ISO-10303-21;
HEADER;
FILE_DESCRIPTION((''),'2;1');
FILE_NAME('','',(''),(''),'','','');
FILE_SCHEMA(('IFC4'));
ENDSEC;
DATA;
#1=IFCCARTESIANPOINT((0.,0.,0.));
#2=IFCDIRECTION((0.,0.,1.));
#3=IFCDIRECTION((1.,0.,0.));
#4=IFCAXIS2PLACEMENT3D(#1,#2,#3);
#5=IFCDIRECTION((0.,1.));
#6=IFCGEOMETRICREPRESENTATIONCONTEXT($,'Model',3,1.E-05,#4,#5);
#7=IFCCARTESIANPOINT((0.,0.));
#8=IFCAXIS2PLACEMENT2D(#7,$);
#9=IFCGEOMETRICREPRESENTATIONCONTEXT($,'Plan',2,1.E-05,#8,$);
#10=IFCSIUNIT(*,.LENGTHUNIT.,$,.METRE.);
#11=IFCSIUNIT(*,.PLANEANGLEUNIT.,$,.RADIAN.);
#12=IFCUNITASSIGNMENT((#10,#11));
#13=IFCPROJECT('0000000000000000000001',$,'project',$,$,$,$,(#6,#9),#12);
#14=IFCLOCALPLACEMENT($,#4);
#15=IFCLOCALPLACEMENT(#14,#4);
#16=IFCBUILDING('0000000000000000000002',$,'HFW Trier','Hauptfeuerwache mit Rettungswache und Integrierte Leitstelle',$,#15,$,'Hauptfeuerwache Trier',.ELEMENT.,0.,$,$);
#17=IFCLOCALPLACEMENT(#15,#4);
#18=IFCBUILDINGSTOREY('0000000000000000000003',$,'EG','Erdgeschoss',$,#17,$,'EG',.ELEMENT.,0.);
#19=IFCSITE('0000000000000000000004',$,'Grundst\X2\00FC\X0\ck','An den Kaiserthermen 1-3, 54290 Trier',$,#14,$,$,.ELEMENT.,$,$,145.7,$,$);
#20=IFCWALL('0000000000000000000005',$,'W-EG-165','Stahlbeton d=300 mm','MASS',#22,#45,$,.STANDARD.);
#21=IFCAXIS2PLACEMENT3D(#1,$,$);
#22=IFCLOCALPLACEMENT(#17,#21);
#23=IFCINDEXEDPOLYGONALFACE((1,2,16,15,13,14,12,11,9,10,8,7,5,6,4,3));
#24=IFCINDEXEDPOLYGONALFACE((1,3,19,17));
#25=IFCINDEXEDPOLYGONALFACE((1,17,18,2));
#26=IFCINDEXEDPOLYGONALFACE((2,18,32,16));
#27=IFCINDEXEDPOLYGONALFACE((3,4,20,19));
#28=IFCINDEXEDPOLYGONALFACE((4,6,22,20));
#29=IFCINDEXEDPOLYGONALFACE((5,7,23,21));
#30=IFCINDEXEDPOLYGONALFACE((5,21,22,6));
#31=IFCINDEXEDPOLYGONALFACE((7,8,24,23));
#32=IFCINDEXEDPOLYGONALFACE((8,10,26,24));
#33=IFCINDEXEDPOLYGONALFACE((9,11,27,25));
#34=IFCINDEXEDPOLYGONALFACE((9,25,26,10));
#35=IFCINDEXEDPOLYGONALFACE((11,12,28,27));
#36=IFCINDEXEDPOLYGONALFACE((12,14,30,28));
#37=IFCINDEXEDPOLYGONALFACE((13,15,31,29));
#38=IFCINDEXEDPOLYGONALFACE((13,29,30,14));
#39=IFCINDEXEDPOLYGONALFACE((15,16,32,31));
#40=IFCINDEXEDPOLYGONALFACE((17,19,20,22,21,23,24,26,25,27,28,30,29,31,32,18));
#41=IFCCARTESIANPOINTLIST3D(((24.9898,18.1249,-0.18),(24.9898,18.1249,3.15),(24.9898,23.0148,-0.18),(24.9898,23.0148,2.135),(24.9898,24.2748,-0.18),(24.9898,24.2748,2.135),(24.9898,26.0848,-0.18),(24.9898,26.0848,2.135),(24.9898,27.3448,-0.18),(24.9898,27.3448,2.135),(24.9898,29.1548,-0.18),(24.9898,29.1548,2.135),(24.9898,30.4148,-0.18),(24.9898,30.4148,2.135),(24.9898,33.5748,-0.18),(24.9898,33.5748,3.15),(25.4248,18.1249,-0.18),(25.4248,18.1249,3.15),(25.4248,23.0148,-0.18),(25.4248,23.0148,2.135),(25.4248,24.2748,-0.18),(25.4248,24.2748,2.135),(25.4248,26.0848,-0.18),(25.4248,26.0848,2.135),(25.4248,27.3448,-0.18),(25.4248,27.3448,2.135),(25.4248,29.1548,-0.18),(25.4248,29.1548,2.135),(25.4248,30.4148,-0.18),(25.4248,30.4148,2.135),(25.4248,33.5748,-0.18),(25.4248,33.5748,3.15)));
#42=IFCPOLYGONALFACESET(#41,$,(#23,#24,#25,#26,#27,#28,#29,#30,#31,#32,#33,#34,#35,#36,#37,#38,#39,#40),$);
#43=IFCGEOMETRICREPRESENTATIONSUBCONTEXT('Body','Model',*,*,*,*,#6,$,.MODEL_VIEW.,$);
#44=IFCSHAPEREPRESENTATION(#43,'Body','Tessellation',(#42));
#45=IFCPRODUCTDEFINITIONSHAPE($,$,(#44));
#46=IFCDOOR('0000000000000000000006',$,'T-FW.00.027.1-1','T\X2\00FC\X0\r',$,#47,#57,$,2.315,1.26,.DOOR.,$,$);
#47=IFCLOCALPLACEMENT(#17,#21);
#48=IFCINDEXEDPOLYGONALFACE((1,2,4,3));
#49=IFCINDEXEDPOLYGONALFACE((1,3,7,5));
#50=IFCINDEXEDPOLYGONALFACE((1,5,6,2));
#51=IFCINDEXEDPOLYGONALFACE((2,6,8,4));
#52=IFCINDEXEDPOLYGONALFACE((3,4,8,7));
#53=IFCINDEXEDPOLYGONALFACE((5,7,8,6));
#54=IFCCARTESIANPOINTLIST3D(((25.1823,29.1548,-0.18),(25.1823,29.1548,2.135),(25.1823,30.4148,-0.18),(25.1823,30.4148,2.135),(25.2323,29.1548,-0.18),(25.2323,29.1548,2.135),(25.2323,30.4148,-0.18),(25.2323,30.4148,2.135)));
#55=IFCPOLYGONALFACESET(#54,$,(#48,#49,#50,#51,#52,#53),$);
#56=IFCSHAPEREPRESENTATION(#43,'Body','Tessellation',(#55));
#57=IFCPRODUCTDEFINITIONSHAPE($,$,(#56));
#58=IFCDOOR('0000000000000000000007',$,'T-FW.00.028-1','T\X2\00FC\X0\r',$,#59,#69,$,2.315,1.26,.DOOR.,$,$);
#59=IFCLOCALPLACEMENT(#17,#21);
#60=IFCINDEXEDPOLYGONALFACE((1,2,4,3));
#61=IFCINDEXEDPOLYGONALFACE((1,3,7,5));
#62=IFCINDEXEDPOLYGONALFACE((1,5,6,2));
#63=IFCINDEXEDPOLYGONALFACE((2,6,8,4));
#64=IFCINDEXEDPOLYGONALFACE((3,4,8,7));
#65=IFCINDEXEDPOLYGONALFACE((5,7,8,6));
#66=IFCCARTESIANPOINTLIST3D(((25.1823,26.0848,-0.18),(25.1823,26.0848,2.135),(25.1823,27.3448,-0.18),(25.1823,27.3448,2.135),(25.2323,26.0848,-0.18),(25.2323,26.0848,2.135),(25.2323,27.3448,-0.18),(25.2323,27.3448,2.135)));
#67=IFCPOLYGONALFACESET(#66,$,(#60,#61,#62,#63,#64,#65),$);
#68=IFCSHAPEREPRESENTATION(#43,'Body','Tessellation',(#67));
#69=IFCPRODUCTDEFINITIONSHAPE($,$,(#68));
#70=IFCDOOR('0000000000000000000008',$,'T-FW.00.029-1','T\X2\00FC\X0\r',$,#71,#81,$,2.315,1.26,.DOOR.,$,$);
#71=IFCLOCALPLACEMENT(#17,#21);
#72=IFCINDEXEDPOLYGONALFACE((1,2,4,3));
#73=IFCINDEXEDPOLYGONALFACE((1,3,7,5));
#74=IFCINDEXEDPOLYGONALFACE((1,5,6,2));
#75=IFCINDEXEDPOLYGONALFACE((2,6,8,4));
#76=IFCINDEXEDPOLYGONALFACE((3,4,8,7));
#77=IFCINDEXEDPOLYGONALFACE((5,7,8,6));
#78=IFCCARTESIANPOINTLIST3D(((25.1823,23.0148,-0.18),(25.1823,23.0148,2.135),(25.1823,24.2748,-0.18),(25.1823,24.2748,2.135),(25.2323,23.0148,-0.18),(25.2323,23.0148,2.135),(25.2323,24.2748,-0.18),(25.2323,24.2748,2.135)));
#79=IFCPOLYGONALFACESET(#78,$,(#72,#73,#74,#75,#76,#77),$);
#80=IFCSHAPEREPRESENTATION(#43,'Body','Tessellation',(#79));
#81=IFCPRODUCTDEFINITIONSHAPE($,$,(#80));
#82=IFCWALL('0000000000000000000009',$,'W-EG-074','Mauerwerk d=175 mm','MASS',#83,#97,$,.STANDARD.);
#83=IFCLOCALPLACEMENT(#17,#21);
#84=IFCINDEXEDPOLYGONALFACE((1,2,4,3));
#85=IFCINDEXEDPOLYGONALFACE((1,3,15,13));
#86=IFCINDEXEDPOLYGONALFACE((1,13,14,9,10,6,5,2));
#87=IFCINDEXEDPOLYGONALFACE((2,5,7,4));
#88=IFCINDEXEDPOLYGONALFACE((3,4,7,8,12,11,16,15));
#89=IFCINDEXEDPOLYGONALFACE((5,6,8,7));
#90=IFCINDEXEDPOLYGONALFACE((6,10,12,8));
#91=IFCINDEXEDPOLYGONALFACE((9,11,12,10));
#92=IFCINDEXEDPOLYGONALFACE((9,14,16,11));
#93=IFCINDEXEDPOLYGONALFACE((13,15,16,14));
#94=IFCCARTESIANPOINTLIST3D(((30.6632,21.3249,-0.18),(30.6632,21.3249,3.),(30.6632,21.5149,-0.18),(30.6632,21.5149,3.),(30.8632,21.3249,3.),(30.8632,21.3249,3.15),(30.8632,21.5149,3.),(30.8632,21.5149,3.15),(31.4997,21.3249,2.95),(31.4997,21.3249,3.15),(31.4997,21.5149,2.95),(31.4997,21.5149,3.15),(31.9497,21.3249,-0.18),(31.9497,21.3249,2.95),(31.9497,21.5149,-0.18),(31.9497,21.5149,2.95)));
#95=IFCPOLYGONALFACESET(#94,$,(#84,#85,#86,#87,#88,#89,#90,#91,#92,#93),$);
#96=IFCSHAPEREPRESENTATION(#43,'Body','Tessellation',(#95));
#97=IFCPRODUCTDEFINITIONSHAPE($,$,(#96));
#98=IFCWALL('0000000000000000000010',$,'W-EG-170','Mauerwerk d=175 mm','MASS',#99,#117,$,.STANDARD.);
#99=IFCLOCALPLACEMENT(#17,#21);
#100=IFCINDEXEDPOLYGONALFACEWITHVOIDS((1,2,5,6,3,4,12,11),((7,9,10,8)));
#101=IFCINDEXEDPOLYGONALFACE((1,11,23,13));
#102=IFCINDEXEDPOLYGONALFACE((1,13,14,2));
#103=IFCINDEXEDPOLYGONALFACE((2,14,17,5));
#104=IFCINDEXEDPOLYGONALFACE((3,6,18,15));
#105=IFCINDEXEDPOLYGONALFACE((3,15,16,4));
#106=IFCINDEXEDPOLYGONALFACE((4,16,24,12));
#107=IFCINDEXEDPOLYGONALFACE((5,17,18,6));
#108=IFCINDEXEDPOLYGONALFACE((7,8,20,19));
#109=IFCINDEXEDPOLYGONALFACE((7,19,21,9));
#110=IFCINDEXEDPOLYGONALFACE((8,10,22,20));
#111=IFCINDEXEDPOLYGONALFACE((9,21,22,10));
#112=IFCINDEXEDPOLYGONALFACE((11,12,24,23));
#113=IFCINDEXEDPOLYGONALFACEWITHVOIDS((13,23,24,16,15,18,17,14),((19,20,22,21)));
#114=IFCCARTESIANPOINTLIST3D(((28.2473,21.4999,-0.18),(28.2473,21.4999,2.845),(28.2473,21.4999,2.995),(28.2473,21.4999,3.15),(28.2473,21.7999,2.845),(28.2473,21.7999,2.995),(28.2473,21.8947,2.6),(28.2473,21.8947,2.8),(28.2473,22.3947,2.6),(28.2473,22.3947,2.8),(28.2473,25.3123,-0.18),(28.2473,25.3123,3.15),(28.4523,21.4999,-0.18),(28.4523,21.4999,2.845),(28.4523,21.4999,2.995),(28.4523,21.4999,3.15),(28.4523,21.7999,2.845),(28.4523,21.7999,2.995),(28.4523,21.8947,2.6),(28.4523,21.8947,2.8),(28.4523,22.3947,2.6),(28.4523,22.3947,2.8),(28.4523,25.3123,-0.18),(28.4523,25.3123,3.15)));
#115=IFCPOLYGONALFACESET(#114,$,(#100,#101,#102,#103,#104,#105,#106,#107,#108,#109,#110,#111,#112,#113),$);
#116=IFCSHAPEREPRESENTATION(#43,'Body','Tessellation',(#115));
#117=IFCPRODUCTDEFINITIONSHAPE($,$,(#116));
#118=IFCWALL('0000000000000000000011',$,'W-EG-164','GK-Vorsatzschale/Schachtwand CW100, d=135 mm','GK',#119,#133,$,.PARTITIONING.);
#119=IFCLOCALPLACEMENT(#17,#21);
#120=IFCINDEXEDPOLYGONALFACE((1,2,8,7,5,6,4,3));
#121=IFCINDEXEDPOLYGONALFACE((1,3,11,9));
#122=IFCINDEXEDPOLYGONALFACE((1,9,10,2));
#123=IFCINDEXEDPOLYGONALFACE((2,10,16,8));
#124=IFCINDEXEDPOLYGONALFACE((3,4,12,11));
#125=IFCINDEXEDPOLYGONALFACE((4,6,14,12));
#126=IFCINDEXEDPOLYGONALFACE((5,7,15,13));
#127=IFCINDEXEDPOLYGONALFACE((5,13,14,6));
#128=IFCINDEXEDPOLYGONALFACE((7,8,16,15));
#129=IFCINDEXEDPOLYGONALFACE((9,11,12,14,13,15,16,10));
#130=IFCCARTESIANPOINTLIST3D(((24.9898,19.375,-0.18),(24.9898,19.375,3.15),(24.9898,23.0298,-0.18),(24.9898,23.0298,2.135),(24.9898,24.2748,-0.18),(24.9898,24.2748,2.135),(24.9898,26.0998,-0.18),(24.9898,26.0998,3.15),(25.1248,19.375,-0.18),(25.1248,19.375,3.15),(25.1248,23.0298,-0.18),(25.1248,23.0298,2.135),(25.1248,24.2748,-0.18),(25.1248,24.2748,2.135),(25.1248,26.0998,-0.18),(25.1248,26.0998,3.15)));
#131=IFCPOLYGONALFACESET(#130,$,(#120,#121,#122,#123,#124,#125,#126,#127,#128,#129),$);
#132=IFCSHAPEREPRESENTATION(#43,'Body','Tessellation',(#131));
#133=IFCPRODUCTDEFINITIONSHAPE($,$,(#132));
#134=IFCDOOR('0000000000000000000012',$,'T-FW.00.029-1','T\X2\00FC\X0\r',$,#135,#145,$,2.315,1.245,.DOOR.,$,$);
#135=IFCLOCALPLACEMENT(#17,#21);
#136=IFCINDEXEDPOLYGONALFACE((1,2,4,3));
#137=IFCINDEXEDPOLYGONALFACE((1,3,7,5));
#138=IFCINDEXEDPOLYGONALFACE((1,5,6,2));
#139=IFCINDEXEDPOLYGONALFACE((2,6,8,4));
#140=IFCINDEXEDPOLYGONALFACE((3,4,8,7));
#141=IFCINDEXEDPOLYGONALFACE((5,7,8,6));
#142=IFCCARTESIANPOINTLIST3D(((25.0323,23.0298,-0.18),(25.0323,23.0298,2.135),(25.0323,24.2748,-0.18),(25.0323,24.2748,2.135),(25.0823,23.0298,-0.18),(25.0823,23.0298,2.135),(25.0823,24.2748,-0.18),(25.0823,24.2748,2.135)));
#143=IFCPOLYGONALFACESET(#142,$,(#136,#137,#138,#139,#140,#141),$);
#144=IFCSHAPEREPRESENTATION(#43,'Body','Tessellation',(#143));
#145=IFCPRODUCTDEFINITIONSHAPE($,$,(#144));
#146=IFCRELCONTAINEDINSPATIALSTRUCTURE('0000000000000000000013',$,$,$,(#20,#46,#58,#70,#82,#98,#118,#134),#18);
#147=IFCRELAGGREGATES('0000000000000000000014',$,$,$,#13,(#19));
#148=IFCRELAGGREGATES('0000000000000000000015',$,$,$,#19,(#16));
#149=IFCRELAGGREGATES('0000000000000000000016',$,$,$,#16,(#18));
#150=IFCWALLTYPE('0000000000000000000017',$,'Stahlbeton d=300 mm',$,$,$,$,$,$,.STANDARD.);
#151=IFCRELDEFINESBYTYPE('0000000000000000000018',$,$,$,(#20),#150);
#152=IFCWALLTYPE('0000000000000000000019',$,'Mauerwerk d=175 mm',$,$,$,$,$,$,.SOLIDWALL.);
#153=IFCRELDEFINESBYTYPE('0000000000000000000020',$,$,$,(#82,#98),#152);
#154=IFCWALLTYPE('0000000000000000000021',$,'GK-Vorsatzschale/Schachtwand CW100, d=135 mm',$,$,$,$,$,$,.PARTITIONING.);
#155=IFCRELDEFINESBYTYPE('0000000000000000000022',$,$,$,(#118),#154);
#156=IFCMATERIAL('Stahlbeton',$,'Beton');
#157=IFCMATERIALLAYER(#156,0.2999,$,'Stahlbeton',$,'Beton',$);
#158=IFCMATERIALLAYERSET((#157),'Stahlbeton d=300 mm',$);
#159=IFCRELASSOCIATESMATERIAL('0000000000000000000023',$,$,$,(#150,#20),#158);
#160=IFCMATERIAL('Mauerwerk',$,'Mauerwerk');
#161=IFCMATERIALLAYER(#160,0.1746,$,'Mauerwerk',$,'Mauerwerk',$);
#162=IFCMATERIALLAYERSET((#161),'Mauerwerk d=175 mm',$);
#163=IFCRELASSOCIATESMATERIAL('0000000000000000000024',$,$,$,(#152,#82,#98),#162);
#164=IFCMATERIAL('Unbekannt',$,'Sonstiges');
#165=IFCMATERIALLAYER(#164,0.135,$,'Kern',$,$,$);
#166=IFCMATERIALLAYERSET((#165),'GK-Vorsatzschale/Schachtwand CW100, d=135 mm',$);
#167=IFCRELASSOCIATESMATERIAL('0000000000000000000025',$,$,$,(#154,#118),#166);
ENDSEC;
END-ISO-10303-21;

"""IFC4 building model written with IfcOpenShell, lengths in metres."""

from ifc_helpers import new_model, si_unit, direction, frame, frame_2d, origin_with_axes, origin_2d, place, context, subcontext, project, spatial, rectangle, extrude, material, layer, layer_set, layer_usage, type_object, element, fill, save


model = new_model("IFC4")

# Units and contexts
model_context = context("Model", 3, precision=1e-05, world=origin_with_axes(), true_north=direction((0.0, 1.0)))
plan_context = context("Plan", 2, precision=1e-05, world=origin_2d())
body_context = subcontext(model_context, "Body", "Model", "MODEL_VIEW")
ifc_project = project(units=[si_unit("LENGTHUNIT", "METRE"), si_unit("PLANEANGLEUNIT", "RADIAN")], contexts=[model_context, plan_context])

# Site, building, storey
site_placement = place(None, origin_with_axes())
site = spatial("IfcSite", under=ifc_project, at=site_placement, Name="Grundstück", Description="An den Kaiserthermen 1-3, 54290 Trier", CompositionType="ELEMENT", RefElevation=145.7)
building_placement = place(site_placement, origin_with_axes())
building = spatial("IfcBuilding", under=site, at=building_placement, Name="HFW Trier", Description="Hauptfeuerwache mit Rettungswache und Integrierte Leitstelle", LongName="Hauptfeuerwache Trier", CompositionType="ELEMENT", ElevationOfRefHeight=0.0)
storey_placement = place(building_placement, origin_with_axes())
storey = spatial("IfcBuildingStorey", under=building, at=storey_placement, Name="EG", Description="Erdgeschoss", LongName="EG", CompositionType="ELEMENT", Elevation=0.0)

# Wall, openings, doors
ifc_material_1 = material(Name="Stahlbeton", Category="Beton")
ifc_layer_1 = layer(ifc_material_1, 0.2999, Name="Stahlbeton", Category="Beton")
ifc_layer_set_1 = layer_set([ifc_layer_1], Name="Stahlbeton d=300 mm")
ifc_layer_usage_1 = layer_usage(ifc_layer_set_1, "AXIS2", "POSITIVE", -0.2175)
wall_type_1 = type_object("IfcWallType", Name="Stahlbeton d=300 mm", PredefinedType="STANDARD", material=ifc_layer_set_1)
wall_1_placement = place(storey_placement, frame((25.2073, 33.5748, -0.18), z_axis=(0.0, 0.0, 1.0), x_axis=(0.0, -1.0, 0.0)))
wall_1 = element("IfcWall", 1, at=wall_1_placement, inside=storey, type_object=wall_type_1, material=ifc_layer_usage_1, Name="W-EG-165", Description="Stahlbeton d=300 mm", ObjectType="MASS", PredefinedType="STANDARD", context=body_context, shape_type="SweptSolid", body=[
    extrude(rectangle(XDim=15.4499, YDim=0.435, at=frame_2d((7.725, 0.0))), origin_with_axes(), (0.0, 0.0, 1.0), 3.33),
])
opening_1_placement = place(wall_1_placement, frame((3.16, 0.0, 0.0), z_axis=(0.0, 0.0, 1.0), x_axis=(1.0, 0.0, 0.0)))
opening_1 = element("IfcOpeningElement", 2, at=opening_1_placement, cuts=wall_1, PredefinedType="OPENING", context=body_context, shape_type="SweptSolid", body=[
    extrude(rectangle(XDim=1.26, YDim=0.535, at=frame_2d((0.63, 0.0))), origin_with_axes(), (0.0, 0.0, 1.0), 2.315),
])
opening_2_placement = place(wall_1_placement, frame((6.23, 0.0, 0.0), z_axis=(0.0, 0.0, 1.0), x_axis=(1.0, 0.0, 0.0)))
opening_2 = element("IfcOpeningElement", 3, at=opening_2_placement, cuts=wall_1, PredefinedType="OPENING", context=body_context, shape_type="SweptSolid", body=[
    extrude(rectangle(XDim=1.26, YDim=0.535, at=frame_2d((0.63, 0.0))), origin_with_axes(), (0.0, 0.0, 1.0), 2.315),
])
opening_3_placement = place(wall_1_placement, frame((9.3, 0.0, 0.0), z_axis=(0.0, 0.0, 1.0), x_axis=(1.0, 0.0, 0.0)))
opening_3 = element("IfcOpeningElement", 4, at=opening_3_placement, cuts=wall_1, PredefinedType="OPENING", context=body_context, shape_type="SweptSolid", body=[
    extrude(rectangle(XDim=1.26, YDim=0.535, at=frame_2d((0.63, 0.0))), origin_with_axes(), (0.0, 0.0, 1.0), 2.315),
])
door_1_placement = place(wall_1_placement, frame((3.16, 0.0, 0.0), z_axis=(0.0, 0.0, 1.0), x_axis=(1.0, 0.0, 0.0)))
door_1 = element("IfcDoor", 5, at=door_1_placement, inside=storey, Name="T-FW.00.027.1-1", Description="Tür", OverallHeight=2.315, OverallWidth=1.26, PredefinedType="DOOR", context=body_context, shape_type="SweptSolid", body=[
    extrude(rectangle(XDim=1.26, YDim=0.05, at=frame_2d((0.63, 0.0))), origin_with_axes(), (0.0, 0.0, 1.0), 2.315),
])
fill(opening_1, door_1)
door_2_placement = place(wall_1_placement, frame((6.23, 0.0, 0.0), z_axis=(0.0, 0.0, 1.0), x_axis=(1.0, 0.0, 0.0)))
door_2 = element("IfcDoor", 6, at=door_2_placement, inside=storey, Name="T-FW.00.028-1", Description="Tür", OverallHeight=2.315, OverallWidth=1.26, PredefinedType="DOOR", context=body_context, shape_type="SweptSolid", body=[
    extrude(rectangle(XDim=1.26, YDim=0.05, at=frame_2d((0.63, 0.0))), origin_with_axes(), (0.0, 0.0, 1.0), 2.315),
])
fill(opening_2, door_2)
door_3_placement = place(wall_1_placement, frame((9.3, 0.0, 0.0), z_axis=(0.0, 0.0, 1.0), x_axis=(1.0, 0.0, 0.0)))
door_3 = element("IfcDoor", 7, at=door_3_placement, inside=storey, Name="T-FW.00.029-1", Description="Tür", OverallHeight=2.315, OverallWidth=1.26, PredefinedType="DOOR", context=body_context, shape_type="SweptSolid", body=[
    extrude(rectangle(XDim=1.26, YDim=0.05, at=frame_2d((0.63, 0.0))), origin_with_axes(), (0.0, 0.0, 1.0), 2.315),
])
fill(opening_3, door_3)

# Walls, openings
ifc_material_2 = material(Name="Mauerwerk", Category="Mauerwerk")
ifc_layer_2 = layer(ifc_material_2, 0.1746, Name="Mauerwerk", Category="Mauerwerk")
ifc_layer_set_2 = layer_set([ifc_layer_2], Name="Mauerwerk d=175 mm")
wall_type_2 = type_object("IfcWallType", Name="Mauerwerk d=175 mm", PredefinedType="SOLIDWALL", material=ifc_layer_set_2)
ifc_layer_usage_2 = layer_usage(ifc_layer_set_2, "AXIS2", "POSITIVE", -0.095)
wall_2_placement = place(storey_placement, frame((30.6632, 21.4199, -0.18), z_axis=(0.0, 0.0, 1.0), x_axis=(1.0, 0.0, 0.0)))
wall_2 = element("IfcWall", 8, at=wall_2_placement, inside=storey, type_object=wall_type_2, material=ifc_layer_usage_2, Name="W-EG-074", Description="Mauerwerk d=175 mm", ObjectType="MASS", PredefinedType="STANDARD", context=body_context, shape_type="SweptSolid", body=[
    extrude(rectangle(XDim=1.2865, YDim=0.19, at=frame_2d((0.6433, 0.0))), origin_with_axes(), (0.0, 0.0, 1.0), 3.33),
])
opening_4_placement = place(wall_2_placement, origin_with_axes())
element("IfcOpeningElement", 9, at=opening_4_placement, cuts=wall_2, ObjectType="Wanddurchbruch", PredefinedType="OPENING", context=body_context, shape_type="SweptSolid", body=[
    extrude(rectangle(XDim=0.2, YDim=0.29, at=frame_2d((0.1, 0.0))), frame((0.0, 0.0, 3.18), z_axis=(0.0, 0.0, 1.0), x_axis=(1.0, 0.0, 0.0)), (0.0, 0.0, 1.0), 0.15),
])
opening_5_placement = place(wall_2_placement, origin_with_axes())
element("IfcOpeningElement", 10, at=opening_5_placement, cuts=wall_2, ObjectType="Wanddurchbruch", PredefinedType="OPENING", context=body_context, shape_type="SweptSolid", body=[
    extrude(rectangle(XDim=0.45, YDim=0.29, at=frame_2d((1.0615, 0.0))), frame((0.0, 0.0, 3.13), z_axis=(0.0, 0.0, 1.0), x_axis=(1.0, 0.0, 0.0)), (0.0, 0.0, 1.0), 0.2),
])
ifc_layer_usage_3 = layer_usage(ifc_layer_set_2, "AXIS2", "POSITIVE", -0.1025)
wall_3_placement = place(storey_placement, frame((28.3498, 25.3123, -0.18), z_axis=(0.0, 0.0, 1.0), x_axis=(0.0, -1.0, 0.0)))
wall_3 = element("IfcWall", 11, at=wall_3_placement, inside=storey, type_object=wall_type_2, material=ifc_layer_usage_3, Name="W-EG-170", Description="Mauerwerk d=175 mm", ObjectType="MASS", PredefinedType="STANDARD", context=body_context, shape_type="SweptSolid", body=[
    extrude(rectangle(XDim=3.8124, YDim=0.205, at=frame_2d((1.9062, 0.0))), origin_with_axes(), (0.0, 0.0, 1.0), 3.33),
])
opening_6_placement = place(wall_3_placement, origin_with_axes())
element("IfcOpeningElement", 12, at=opening_6_placement, cuts=wall_3, ObjectType="Wanddurchbruch", PredefinedType="OPENING", context=body_context, shape_type="SweptSolid", body=[
    extrude(rectangle(XDim=0.3, YDim=0.305, at=frame_2d((3.6624, 0.0))), frame((0.0, 0.0, 3.025), z_axis=(0.0, 0.0, 1.0), x_axis=(1.0, 0.0, 0.0)), (0.0, 0.0, 1.0), 0.15),
])
opening_7_placement = place(wall_3_placement, origin_with_axes())
element("IfcOpeningElement", 13, at=opening_7_placement, cuts=wall_3, ObjectType="Wanddurchbruch", PredefinedType="OPENING", context=body_context, shape_type="SweptSolid", body=[
    extrude(rectangle(XDim=0.5, YDim=0.305, at=frame_2d((3.1676, 0.0))), frame((0.0, 0.0, 2.78), z_axis=(0.0, 0.0, 1.0), x_axis=(1.0, 0.0, 0.0)), (0.0, 0.0, 1.0), 0.2),
])

# Wall, opening, door
ifc_material_3 = material(Name="Unbekannt", Category="Sonstiges")
ifc_layer_3 = layer(ifc_material_3, 0.135, Name="Kern")
ifc_layer_set_3 = layer_set([ifc_layer_3], Name="GK-Vorsatzschale/Schachtwand CW100, d=135 mm")
ifc_layer_usage_4 = layer_usage(ifc_layer_set_3, "AXIS2", "POSITIVE", -0.0675)
wall_type_3 = type_object("IfcWallType", Name="GK-Vorsatzschale/Schachtwand CW100, d=135 mm", PredefinedType="PARTITIONING", material=ifc_layer_set_3)
wall_4_placement = place(storey_placement, frame((25.0573, 26.0998, -0.18), z_axis=(0.0, 0.0, 1.0), x_axis=(0.0, -1.0, 0.0)))
wall_4 = element("IfcWall", 14, at=wall_4_placement, inside=storey, type_object=wall_type_3, material=ifc_layer_usage_4, Name="W-EG-164", Description="GK-Vorsatzschale/Schachtwand CW100, d=135 mm", ObjectType="GK", PredefinedType="PARTITIONING", context=body_context, shape_type="SweptSolid", body=[
    extrude(rectangle(XDim=6.7248, YDim=0.135, at=frame_2d((3.3624, 0.0))), origin_with_axes(), (0.0, 0.0, 1.0), 3.33),
])
opening_8_placement = place(wall_4_placement, frame((1.825, 0.0, 0.0), z_axis=(0.0, 0.0, 1.0), x_axis=(1.0, 0.0, 0.0)))
opening_8 = element("IfcOpeningElement", 15, at=opening_8_placement, cuts=wall_4, PredefinedType="OPENING", context=body_context, shape_type="SweptSolid", body=[
    extrude(rectangle(XDim=1.245, YDim=0.235, at=frame_2d((0.6225, 0.0))), origin_with_axes(), (0.0, 0.0, 1.0), 2.315),
])
door_4_placement = place(wall_4_placement, frame((1.825, 0.0, 0.0), z_axis=(0.0, 0.0, 1.0), x_axis=(1.0, 0.0, 0.0)))
door_4 = element("IfcDoor", 16, at=door_4_placement, inside=storey, Name="T-FW.00.029-1", Description="Tür", OverallHeight=2.315, OverallWidth=1.245, PredefinedType="DOOR", context=body_context, shape_type="SweptSolid", body=[
    extrude(rectangle(XDim=1.245, YDim=0.05, at=frame_2d((0.6225, 0.0))), origin_with_axes(), (0.0, 0.0, 1.0), 2.315),
])
fill(opening_8, door_4)

save(model, "model.ifc")
